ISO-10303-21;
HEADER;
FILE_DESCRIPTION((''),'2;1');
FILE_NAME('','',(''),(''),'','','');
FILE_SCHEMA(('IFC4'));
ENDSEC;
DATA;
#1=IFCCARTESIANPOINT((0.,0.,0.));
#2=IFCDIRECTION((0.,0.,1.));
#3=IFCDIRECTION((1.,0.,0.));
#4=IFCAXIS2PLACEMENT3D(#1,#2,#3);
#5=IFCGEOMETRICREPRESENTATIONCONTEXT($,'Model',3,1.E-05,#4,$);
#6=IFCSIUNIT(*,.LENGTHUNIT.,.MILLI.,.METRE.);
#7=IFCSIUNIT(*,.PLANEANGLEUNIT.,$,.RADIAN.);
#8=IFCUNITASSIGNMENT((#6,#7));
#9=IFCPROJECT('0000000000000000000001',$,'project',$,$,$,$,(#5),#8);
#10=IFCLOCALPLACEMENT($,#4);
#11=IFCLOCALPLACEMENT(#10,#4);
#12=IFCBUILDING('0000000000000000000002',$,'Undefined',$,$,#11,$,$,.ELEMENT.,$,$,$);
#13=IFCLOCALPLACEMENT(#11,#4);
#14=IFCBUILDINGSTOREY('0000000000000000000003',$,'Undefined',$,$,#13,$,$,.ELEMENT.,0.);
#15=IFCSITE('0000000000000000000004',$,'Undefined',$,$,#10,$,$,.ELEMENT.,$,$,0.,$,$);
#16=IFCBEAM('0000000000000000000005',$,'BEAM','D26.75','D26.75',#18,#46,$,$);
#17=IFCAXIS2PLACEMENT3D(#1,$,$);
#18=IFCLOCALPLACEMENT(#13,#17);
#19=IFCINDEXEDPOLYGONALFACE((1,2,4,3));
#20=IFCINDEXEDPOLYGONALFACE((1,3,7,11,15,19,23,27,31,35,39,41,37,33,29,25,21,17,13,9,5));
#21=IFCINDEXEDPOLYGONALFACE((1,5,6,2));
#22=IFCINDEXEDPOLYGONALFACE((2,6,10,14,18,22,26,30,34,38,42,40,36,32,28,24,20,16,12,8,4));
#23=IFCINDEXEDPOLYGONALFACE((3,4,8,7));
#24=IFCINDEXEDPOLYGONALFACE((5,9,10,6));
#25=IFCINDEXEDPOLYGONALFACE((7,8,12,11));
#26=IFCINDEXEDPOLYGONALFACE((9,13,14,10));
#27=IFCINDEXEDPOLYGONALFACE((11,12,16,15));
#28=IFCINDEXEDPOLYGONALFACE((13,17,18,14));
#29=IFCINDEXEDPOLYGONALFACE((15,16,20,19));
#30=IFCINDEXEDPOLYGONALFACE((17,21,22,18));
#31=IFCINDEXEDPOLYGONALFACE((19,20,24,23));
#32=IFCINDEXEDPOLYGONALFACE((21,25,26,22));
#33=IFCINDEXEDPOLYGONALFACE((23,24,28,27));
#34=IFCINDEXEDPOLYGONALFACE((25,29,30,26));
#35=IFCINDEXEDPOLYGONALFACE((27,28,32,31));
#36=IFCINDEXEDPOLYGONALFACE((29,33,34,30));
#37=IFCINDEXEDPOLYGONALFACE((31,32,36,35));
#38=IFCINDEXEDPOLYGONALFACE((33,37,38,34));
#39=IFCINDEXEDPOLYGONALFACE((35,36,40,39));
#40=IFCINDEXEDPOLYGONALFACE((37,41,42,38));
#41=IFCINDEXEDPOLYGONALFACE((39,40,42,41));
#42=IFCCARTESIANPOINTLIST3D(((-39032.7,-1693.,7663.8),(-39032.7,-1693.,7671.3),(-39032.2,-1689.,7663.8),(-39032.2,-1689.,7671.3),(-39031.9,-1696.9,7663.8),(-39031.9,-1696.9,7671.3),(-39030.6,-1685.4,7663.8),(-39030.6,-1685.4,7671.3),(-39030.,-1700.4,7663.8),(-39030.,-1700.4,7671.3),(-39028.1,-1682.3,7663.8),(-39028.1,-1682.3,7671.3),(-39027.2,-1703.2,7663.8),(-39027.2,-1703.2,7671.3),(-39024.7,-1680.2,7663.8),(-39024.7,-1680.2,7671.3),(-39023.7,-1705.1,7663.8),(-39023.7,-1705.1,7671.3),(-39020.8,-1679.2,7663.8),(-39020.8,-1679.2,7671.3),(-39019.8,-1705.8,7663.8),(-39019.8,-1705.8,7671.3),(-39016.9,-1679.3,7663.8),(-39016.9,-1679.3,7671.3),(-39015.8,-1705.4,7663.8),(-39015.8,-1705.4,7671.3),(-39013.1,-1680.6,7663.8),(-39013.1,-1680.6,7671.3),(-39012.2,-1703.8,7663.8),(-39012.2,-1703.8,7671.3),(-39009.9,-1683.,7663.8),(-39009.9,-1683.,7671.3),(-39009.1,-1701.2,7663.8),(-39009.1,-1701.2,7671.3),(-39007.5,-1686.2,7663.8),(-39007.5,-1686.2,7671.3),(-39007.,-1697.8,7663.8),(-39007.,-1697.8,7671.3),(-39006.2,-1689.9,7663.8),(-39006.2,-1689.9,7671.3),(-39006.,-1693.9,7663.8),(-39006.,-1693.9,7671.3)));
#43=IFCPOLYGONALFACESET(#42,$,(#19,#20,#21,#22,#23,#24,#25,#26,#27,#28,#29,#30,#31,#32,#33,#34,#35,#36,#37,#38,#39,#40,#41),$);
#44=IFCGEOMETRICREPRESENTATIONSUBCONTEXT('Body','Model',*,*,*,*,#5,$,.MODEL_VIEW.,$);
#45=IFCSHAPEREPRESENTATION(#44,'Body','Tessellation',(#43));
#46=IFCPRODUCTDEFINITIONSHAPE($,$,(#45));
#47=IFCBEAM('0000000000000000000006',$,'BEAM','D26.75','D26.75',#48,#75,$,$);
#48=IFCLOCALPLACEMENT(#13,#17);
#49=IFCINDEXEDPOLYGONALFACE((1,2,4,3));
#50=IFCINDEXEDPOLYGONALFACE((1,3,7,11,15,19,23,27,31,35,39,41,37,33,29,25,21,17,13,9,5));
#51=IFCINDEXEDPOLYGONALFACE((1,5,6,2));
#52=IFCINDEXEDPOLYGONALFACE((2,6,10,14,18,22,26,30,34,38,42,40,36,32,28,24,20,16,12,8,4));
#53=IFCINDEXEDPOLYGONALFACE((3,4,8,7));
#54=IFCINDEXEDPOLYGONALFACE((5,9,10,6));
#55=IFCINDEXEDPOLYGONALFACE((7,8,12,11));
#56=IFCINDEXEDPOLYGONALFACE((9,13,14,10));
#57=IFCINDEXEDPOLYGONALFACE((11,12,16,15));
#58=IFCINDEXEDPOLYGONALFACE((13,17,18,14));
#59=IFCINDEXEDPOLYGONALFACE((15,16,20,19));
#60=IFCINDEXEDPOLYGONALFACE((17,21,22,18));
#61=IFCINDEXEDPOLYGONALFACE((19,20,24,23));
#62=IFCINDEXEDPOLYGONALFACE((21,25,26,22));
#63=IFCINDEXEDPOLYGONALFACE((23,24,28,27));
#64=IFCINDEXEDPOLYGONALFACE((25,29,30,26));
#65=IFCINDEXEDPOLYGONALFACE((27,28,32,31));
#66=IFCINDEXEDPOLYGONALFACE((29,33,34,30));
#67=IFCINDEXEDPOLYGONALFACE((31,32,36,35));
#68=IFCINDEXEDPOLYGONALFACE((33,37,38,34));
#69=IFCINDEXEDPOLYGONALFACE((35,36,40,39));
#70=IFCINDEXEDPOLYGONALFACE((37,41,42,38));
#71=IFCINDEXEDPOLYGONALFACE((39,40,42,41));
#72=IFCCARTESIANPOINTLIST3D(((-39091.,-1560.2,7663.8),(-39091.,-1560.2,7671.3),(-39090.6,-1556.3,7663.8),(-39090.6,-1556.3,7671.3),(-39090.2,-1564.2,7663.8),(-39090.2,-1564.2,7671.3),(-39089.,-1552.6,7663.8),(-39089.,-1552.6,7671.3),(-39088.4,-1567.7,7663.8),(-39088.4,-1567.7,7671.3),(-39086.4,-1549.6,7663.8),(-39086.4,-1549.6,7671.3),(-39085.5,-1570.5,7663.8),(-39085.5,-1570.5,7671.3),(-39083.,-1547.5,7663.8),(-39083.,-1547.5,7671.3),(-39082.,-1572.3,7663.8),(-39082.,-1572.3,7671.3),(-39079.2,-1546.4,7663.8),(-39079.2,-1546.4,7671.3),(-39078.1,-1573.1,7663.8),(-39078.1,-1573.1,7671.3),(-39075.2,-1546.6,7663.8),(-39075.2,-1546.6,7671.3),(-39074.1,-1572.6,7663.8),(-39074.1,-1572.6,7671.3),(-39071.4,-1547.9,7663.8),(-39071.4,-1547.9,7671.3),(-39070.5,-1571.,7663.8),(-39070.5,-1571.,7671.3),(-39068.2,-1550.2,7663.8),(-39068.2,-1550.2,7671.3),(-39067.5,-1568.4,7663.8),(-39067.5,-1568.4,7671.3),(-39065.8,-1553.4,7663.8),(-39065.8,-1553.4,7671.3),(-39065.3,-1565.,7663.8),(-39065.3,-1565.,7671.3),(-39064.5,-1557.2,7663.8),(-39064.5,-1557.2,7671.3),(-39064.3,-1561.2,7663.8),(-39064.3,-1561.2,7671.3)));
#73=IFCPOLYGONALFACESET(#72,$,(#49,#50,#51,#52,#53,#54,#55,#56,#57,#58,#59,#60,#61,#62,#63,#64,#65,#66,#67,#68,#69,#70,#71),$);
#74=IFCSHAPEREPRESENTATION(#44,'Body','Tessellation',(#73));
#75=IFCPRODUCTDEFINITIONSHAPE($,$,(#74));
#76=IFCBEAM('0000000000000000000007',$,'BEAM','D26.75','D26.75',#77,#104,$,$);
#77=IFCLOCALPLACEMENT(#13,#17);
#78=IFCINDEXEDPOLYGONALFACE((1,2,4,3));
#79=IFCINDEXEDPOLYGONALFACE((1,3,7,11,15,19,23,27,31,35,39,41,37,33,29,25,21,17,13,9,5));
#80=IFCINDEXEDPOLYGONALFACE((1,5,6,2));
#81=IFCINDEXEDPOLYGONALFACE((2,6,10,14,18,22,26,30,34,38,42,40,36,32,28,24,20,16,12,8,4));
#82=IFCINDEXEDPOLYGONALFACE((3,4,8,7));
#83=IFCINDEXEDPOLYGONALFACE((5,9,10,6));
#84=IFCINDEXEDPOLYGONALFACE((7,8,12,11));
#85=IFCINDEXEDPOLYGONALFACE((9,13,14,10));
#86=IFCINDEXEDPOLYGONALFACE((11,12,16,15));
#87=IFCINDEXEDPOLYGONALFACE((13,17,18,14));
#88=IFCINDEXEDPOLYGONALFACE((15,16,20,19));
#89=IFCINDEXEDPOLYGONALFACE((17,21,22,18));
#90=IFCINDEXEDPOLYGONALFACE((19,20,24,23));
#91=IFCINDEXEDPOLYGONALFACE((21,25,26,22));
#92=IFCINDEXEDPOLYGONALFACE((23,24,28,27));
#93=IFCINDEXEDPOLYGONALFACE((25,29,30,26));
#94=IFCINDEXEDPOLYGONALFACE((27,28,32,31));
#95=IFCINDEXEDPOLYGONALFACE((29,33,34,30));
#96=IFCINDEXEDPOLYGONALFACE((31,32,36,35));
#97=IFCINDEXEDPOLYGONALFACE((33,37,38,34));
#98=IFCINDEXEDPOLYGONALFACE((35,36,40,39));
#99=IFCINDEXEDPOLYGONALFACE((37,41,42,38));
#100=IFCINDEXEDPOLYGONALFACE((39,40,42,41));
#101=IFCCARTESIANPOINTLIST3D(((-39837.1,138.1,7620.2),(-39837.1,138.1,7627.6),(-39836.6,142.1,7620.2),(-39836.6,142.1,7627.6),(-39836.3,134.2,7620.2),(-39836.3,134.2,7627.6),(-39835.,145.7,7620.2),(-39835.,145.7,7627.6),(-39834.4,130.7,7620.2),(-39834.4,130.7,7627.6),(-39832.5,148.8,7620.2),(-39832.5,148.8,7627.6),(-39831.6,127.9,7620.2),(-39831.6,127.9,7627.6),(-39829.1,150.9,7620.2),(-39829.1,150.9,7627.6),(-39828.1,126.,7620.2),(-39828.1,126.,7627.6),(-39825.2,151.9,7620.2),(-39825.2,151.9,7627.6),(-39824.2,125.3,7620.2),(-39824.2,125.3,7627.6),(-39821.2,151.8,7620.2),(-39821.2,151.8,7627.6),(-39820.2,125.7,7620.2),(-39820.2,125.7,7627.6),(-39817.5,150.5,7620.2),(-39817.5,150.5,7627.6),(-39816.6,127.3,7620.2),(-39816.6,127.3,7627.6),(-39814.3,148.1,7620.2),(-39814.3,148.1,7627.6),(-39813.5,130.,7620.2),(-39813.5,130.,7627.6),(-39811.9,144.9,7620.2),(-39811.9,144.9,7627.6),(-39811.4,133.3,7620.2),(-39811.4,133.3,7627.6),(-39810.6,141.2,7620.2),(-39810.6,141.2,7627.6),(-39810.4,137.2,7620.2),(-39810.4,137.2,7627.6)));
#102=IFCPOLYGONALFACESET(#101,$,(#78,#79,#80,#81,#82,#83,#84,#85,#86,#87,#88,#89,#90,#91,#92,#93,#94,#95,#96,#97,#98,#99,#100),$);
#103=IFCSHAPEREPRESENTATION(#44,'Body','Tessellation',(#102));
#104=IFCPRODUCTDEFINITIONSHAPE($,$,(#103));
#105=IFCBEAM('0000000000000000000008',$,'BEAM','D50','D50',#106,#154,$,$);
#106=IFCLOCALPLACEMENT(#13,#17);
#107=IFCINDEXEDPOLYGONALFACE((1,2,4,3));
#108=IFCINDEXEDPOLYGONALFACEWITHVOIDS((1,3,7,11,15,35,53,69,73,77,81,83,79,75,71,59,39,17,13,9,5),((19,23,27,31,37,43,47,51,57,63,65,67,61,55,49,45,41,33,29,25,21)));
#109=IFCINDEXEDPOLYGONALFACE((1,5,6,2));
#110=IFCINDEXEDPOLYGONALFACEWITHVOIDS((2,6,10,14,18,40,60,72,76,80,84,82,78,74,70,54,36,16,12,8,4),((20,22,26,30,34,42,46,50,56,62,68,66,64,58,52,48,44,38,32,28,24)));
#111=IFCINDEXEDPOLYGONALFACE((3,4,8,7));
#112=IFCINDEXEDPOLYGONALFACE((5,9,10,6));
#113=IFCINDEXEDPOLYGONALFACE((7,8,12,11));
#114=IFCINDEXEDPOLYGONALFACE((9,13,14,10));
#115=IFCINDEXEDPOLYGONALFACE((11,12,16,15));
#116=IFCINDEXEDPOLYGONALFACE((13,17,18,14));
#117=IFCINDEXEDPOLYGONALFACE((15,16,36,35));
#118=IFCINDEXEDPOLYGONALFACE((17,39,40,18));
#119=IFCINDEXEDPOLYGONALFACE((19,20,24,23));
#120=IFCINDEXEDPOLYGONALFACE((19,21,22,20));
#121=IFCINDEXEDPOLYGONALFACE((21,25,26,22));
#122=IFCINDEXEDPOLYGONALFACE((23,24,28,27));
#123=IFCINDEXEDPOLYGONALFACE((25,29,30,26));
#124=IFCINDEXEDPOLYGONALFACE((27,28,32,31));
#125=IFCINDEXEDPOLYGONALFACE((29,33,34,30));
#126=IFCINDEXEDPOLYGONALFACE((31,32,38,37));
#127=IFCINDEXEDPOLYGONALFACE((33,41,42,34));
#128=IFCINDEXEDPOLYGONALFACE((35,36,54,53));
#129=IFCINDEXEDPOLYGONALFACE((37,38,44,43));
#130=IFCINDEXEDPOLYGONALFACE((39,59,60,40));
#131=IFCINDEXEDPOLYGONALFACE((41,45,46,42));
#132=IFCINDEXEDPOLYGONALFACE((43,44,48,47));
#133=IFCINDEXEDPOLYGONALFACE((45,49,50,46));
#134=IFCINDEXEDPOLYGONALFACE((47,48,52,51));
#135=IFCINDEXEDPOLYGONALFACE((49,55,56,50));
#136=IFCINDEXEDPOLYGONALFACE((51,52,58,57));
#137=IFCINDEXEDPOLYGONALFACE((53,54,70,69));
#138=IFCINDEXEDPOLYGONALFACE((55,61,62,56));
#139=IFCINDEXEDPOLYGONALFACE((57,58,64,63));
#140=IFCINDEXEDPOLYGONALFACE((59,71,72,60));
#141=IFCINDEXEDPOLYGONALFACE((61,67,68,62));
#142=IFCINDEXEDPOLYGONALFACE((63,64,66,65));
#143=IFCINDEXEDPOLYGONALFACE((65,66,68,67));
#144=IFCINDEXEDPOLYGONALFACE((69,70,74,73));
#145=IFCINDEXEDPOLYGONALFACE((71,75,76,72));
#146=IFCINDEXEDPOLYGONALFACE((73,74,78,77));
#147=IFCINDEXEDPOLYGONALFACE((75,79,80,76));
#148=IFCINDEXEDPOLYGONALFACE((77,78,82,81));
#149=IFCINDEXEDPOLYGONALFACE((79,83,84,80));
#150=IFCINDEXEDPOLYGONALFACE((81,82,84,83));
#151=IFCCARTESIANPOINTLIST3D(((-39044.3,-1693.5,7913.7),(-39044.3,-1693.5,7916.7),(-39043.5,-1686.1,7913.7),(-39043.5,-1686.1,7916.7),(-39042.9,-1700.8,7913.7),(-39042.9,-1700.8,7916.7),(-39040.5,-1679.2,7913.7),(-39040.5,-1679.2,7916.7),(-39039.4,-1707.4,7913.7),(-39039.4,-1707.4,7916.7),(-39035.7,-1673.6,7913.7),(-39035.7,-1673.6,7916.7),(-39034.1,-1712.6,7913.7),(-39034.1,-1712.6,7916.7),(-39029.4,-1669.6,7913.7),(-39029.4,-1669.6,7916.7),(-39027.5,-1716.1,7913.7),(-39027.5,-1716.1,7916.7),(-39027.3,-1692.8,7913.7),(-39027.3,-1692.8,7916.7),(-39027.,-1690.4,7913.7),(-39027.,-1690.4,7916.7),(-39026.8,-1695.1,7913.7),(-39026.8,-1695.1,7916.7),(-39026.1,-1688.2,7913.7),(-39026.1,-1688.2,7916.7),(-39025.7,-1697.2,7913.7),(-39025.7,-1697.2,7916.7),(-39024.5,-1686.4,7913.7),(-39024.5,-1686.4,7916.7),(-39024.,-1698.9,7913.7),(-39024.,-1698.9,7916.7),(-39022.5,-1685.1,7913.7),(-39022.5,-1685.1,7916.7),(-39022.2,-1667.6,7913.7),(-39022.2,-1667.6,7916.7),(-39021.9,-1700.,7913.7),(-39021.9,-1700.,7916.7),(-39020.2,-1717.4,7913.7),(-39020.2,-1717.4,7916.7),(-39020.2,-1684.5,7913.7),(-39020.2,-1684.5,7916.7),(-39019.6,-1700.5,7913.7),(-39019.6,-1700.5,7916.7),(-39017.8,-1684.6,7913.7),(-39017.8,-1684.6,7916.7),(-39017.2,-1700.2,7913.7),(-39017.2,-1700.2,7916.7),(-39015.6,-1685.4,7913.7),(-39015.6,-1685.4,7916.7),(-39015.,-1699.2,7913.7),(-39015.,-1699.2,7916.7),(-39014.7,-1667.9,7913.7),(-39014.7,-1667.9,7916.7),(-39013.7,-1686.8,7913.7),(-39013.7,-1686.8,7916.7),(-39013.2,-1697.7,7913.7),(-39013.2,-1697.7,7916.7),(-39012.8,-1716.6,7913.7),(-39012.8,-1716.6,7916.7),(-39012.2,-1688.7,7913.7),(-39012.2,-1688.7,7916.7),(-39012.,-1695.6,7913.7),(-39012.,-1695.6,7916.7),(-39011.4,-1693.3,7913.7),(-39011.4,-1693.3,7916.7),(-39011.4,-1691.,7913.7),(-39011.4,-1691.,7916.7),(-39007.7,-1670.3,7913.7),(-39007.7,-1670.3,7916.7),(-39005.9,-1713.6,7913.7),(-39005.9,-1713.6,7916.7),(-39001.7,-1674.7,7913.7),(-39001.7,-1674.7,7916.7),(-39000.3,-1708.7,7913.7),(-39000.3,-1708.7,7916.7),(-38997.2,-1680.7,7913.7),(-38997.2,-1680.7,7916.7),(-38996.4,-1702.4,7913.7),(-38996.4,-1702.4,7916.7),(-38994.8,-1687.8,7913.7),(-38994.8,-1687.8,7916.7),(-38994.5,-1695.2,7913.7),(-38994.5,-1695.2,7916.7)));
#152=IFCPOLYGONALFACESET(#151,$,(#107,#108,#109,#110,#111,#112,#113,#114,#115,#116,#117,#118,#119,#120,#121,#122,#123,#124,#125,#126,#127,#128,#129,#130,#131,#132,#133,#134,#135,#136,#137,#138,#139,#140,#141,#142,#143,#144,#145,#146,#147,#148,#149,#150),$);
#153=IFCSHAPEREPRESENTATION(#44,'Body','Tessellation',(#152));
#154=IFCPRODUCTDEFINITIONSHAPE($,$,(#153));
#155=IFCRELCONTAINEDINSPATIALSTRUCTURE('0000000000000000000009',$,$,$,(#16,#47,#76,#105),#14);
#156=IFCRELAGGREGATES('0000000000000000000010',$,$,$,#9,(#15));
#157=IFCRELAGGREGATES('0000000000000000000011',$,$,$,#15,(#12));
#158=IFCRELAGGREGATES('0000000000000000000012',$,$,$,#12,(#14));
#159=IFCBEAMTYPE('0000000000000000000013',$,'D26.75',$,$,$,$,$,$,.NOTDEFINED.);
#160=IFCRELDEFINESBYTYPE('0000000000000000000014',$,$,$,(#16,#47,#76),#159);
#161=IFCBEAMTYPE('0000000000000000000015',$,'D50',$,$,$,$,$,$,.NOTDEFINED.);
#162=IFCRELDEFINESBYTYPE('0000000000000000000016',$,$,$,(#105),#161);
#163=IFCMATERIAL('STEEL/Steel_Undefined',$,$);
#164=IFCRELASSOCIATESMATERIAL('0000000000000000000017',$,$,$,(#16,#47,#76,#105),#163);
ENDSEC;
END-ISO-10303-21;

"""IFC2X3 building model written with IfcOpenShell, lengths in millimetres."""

from ifc_helpers import new_model, si_unit, frame, origin_with_axes, origin_2d_with_axis, place, context, subcontext, project, spatial, circle, extrude, material, type_object, element, save


model = new_model("IFC2X3")

# Units and contexts
model_context = context("Model", 3, precision=1e-05, world=origin_with_axes())
body_context = subcontext(model_context, "Body", "Model", "MODEL_VIEW")
ifc_project = project(units=[si_unit("LENGTHUNIT", "METRE", prefix="MILLI"), si_unit("PLANEANGLEUNIT", "RADIAN")], contexts=[model_context])

# Site, building, storey
site_placement = place(None, origin_with_axes())
site = spatial("IfcSite", under=ifc_project, at=site_placement, Name="Undefined", CompositionType="ELEMENT", RefElevation=0.0)
building_placement = place(site_placement, origin_with_axes())
building = spatial("IfcBuilding", under=site, at=building_placement, Name="Undefined", CompositionType="ELEMENT")
storey_placement = place(building_placement, origin_with_axes())
storey = spatial("IfcBuildingStorey", under=building, at=storey_placement, Name="Undefined", CompositionType="ELEMENT", Elevation=0.0)

# Shared definitions
ifc_material = material(Name="STEEL/Steel_Undefined")
beam_type_1 = type_object("IfcBeamType", Name="D26.75", PredefinedType="NOTDEFINED")

# Beam
beam_1_placement = place(storey_placement, frame((-39019.3, -1692.5, 7671.3), z_axis=(-0.915553, -0.402198, 0.0), x_axis=(0.0, 0.0, -1.0)))
element("IfcBeam", 1, at=beam_1_placement, inside=storey, type_object=beam_type_1, material=ifc_material, Name="BEAM", Description="D26.75", ObjectType="D26.75", context=body_context, shape_type="SweptSolid", body=[
    extrude(circle(Radius=13.4, at=origin_2d_with_axis()), frame((7.4, 0.0, 0.0), z_axis=(-1.0, 0.0, 0.0), x_axis=(0.0, -1.0, 0.0)), (0.0, 0.0, 1.0), 7.4),
])

# Beam
beam_2_placement = place(storey_placement, frame((-39077.6, -1559.7, 7671.3), z_axis=(-0.915553, -0.402198, 0.0), x_axis=(0.0, 0.0, -1.0)))
element("IfcBeam", 2, at=beam_2_placement, inside=storey, type_object=beam_type_1, material=ifc_material, Name="BEAM", Description="D26.75", ObjectType="D26.75", context=body_context, shape_type="SweptSolid", body=[
    extrude(circle(Radius=13.4, at=origin_2d_with_axis()), frame((7.4, 0.0, 0.0), z_axis=(-1.0, 0.0, 0.0), x_axis=(0.0, -1.0, 0.0)), (0.0, 0.0, 1.0), 7.4),
])

# Beam
beam_3_placement = place(storey_placement, frame((-39823.7, 138.7, 7627.6), z_axis=(-0.915553, -0.402198, 0.0), x_axis=(0.0, 0.0, -1.0)))
element("IfcBeam", 3, at=beam_3_placement, inside=storey, type_object=beam_type_1, material=ifc_material, Name="BEAM", Description="D26.75", ObjectType="D26.75", context=body_context, shape_type="SweptSolid", body=[
    extrude(circle(Radius=13.4, at=origin_2d_with_axis()), frame((7.4, 0.0, 0.0), z_axis=(-1.0, 0.0, 0.0), x_axis=(0.0, -1.0, 0.0)), (0.0, 0.0, 1.0), 7.4),
])

# Beam, opening
beam_type_2 = type_object("IfcBeamType", Name="D50", PredefinedType="NOTDEFINED")
beam_4_placement = place(storey_placement, frame((-39019.3, -1692.5, 7916.7), z_axis=(-0.915553, -0.402198, 0.0), x_axis=(0.0, 0.0, -1.0)))
beam_4 = element("IfcBeam", 4, at=beam_4_placement, inside=storey, type_object=beam_type_2, material=ifc_material, Name="BEAM", Description="D50", ObjectType="D50", context=body_context, shape_type="SweptSolid", body=[
    extrude(circle(Radius=25.0, at=origin_2d_with_axis()), frame((3.0, 0.0, 0.0), z_axis=(-1.0, 0.0, 0.0), x_axis=(0.0, -1.0, 0.0)), (0.0, 0.0, 1.0), 3.0),
])
opening_1_placement = place(storey_placement, frame((-39019.3, -1692.5, 7916.7), z_axis=(-0.915553, -0.402198, 0.0), x_axis=(0.0, 0.0, -1.0)))
element("IfcOpeningElement", 5, at=opening_1_placement, cuts=beam_4, ObjectType="Recess", context=body_context, shape_type="SweptSolid", body=[
    extrude(circle(Radius=8.0, at=origin_2d_with_axis()), frame((245.5, 0.0, 0.0), z_axis=(-1.0, 0.0, 0.0), x_axis=(0.0, -1.0, 0.0)), (0.0, 0.0, 1.0), 292.6),
])

save(model, "model.ifc")
